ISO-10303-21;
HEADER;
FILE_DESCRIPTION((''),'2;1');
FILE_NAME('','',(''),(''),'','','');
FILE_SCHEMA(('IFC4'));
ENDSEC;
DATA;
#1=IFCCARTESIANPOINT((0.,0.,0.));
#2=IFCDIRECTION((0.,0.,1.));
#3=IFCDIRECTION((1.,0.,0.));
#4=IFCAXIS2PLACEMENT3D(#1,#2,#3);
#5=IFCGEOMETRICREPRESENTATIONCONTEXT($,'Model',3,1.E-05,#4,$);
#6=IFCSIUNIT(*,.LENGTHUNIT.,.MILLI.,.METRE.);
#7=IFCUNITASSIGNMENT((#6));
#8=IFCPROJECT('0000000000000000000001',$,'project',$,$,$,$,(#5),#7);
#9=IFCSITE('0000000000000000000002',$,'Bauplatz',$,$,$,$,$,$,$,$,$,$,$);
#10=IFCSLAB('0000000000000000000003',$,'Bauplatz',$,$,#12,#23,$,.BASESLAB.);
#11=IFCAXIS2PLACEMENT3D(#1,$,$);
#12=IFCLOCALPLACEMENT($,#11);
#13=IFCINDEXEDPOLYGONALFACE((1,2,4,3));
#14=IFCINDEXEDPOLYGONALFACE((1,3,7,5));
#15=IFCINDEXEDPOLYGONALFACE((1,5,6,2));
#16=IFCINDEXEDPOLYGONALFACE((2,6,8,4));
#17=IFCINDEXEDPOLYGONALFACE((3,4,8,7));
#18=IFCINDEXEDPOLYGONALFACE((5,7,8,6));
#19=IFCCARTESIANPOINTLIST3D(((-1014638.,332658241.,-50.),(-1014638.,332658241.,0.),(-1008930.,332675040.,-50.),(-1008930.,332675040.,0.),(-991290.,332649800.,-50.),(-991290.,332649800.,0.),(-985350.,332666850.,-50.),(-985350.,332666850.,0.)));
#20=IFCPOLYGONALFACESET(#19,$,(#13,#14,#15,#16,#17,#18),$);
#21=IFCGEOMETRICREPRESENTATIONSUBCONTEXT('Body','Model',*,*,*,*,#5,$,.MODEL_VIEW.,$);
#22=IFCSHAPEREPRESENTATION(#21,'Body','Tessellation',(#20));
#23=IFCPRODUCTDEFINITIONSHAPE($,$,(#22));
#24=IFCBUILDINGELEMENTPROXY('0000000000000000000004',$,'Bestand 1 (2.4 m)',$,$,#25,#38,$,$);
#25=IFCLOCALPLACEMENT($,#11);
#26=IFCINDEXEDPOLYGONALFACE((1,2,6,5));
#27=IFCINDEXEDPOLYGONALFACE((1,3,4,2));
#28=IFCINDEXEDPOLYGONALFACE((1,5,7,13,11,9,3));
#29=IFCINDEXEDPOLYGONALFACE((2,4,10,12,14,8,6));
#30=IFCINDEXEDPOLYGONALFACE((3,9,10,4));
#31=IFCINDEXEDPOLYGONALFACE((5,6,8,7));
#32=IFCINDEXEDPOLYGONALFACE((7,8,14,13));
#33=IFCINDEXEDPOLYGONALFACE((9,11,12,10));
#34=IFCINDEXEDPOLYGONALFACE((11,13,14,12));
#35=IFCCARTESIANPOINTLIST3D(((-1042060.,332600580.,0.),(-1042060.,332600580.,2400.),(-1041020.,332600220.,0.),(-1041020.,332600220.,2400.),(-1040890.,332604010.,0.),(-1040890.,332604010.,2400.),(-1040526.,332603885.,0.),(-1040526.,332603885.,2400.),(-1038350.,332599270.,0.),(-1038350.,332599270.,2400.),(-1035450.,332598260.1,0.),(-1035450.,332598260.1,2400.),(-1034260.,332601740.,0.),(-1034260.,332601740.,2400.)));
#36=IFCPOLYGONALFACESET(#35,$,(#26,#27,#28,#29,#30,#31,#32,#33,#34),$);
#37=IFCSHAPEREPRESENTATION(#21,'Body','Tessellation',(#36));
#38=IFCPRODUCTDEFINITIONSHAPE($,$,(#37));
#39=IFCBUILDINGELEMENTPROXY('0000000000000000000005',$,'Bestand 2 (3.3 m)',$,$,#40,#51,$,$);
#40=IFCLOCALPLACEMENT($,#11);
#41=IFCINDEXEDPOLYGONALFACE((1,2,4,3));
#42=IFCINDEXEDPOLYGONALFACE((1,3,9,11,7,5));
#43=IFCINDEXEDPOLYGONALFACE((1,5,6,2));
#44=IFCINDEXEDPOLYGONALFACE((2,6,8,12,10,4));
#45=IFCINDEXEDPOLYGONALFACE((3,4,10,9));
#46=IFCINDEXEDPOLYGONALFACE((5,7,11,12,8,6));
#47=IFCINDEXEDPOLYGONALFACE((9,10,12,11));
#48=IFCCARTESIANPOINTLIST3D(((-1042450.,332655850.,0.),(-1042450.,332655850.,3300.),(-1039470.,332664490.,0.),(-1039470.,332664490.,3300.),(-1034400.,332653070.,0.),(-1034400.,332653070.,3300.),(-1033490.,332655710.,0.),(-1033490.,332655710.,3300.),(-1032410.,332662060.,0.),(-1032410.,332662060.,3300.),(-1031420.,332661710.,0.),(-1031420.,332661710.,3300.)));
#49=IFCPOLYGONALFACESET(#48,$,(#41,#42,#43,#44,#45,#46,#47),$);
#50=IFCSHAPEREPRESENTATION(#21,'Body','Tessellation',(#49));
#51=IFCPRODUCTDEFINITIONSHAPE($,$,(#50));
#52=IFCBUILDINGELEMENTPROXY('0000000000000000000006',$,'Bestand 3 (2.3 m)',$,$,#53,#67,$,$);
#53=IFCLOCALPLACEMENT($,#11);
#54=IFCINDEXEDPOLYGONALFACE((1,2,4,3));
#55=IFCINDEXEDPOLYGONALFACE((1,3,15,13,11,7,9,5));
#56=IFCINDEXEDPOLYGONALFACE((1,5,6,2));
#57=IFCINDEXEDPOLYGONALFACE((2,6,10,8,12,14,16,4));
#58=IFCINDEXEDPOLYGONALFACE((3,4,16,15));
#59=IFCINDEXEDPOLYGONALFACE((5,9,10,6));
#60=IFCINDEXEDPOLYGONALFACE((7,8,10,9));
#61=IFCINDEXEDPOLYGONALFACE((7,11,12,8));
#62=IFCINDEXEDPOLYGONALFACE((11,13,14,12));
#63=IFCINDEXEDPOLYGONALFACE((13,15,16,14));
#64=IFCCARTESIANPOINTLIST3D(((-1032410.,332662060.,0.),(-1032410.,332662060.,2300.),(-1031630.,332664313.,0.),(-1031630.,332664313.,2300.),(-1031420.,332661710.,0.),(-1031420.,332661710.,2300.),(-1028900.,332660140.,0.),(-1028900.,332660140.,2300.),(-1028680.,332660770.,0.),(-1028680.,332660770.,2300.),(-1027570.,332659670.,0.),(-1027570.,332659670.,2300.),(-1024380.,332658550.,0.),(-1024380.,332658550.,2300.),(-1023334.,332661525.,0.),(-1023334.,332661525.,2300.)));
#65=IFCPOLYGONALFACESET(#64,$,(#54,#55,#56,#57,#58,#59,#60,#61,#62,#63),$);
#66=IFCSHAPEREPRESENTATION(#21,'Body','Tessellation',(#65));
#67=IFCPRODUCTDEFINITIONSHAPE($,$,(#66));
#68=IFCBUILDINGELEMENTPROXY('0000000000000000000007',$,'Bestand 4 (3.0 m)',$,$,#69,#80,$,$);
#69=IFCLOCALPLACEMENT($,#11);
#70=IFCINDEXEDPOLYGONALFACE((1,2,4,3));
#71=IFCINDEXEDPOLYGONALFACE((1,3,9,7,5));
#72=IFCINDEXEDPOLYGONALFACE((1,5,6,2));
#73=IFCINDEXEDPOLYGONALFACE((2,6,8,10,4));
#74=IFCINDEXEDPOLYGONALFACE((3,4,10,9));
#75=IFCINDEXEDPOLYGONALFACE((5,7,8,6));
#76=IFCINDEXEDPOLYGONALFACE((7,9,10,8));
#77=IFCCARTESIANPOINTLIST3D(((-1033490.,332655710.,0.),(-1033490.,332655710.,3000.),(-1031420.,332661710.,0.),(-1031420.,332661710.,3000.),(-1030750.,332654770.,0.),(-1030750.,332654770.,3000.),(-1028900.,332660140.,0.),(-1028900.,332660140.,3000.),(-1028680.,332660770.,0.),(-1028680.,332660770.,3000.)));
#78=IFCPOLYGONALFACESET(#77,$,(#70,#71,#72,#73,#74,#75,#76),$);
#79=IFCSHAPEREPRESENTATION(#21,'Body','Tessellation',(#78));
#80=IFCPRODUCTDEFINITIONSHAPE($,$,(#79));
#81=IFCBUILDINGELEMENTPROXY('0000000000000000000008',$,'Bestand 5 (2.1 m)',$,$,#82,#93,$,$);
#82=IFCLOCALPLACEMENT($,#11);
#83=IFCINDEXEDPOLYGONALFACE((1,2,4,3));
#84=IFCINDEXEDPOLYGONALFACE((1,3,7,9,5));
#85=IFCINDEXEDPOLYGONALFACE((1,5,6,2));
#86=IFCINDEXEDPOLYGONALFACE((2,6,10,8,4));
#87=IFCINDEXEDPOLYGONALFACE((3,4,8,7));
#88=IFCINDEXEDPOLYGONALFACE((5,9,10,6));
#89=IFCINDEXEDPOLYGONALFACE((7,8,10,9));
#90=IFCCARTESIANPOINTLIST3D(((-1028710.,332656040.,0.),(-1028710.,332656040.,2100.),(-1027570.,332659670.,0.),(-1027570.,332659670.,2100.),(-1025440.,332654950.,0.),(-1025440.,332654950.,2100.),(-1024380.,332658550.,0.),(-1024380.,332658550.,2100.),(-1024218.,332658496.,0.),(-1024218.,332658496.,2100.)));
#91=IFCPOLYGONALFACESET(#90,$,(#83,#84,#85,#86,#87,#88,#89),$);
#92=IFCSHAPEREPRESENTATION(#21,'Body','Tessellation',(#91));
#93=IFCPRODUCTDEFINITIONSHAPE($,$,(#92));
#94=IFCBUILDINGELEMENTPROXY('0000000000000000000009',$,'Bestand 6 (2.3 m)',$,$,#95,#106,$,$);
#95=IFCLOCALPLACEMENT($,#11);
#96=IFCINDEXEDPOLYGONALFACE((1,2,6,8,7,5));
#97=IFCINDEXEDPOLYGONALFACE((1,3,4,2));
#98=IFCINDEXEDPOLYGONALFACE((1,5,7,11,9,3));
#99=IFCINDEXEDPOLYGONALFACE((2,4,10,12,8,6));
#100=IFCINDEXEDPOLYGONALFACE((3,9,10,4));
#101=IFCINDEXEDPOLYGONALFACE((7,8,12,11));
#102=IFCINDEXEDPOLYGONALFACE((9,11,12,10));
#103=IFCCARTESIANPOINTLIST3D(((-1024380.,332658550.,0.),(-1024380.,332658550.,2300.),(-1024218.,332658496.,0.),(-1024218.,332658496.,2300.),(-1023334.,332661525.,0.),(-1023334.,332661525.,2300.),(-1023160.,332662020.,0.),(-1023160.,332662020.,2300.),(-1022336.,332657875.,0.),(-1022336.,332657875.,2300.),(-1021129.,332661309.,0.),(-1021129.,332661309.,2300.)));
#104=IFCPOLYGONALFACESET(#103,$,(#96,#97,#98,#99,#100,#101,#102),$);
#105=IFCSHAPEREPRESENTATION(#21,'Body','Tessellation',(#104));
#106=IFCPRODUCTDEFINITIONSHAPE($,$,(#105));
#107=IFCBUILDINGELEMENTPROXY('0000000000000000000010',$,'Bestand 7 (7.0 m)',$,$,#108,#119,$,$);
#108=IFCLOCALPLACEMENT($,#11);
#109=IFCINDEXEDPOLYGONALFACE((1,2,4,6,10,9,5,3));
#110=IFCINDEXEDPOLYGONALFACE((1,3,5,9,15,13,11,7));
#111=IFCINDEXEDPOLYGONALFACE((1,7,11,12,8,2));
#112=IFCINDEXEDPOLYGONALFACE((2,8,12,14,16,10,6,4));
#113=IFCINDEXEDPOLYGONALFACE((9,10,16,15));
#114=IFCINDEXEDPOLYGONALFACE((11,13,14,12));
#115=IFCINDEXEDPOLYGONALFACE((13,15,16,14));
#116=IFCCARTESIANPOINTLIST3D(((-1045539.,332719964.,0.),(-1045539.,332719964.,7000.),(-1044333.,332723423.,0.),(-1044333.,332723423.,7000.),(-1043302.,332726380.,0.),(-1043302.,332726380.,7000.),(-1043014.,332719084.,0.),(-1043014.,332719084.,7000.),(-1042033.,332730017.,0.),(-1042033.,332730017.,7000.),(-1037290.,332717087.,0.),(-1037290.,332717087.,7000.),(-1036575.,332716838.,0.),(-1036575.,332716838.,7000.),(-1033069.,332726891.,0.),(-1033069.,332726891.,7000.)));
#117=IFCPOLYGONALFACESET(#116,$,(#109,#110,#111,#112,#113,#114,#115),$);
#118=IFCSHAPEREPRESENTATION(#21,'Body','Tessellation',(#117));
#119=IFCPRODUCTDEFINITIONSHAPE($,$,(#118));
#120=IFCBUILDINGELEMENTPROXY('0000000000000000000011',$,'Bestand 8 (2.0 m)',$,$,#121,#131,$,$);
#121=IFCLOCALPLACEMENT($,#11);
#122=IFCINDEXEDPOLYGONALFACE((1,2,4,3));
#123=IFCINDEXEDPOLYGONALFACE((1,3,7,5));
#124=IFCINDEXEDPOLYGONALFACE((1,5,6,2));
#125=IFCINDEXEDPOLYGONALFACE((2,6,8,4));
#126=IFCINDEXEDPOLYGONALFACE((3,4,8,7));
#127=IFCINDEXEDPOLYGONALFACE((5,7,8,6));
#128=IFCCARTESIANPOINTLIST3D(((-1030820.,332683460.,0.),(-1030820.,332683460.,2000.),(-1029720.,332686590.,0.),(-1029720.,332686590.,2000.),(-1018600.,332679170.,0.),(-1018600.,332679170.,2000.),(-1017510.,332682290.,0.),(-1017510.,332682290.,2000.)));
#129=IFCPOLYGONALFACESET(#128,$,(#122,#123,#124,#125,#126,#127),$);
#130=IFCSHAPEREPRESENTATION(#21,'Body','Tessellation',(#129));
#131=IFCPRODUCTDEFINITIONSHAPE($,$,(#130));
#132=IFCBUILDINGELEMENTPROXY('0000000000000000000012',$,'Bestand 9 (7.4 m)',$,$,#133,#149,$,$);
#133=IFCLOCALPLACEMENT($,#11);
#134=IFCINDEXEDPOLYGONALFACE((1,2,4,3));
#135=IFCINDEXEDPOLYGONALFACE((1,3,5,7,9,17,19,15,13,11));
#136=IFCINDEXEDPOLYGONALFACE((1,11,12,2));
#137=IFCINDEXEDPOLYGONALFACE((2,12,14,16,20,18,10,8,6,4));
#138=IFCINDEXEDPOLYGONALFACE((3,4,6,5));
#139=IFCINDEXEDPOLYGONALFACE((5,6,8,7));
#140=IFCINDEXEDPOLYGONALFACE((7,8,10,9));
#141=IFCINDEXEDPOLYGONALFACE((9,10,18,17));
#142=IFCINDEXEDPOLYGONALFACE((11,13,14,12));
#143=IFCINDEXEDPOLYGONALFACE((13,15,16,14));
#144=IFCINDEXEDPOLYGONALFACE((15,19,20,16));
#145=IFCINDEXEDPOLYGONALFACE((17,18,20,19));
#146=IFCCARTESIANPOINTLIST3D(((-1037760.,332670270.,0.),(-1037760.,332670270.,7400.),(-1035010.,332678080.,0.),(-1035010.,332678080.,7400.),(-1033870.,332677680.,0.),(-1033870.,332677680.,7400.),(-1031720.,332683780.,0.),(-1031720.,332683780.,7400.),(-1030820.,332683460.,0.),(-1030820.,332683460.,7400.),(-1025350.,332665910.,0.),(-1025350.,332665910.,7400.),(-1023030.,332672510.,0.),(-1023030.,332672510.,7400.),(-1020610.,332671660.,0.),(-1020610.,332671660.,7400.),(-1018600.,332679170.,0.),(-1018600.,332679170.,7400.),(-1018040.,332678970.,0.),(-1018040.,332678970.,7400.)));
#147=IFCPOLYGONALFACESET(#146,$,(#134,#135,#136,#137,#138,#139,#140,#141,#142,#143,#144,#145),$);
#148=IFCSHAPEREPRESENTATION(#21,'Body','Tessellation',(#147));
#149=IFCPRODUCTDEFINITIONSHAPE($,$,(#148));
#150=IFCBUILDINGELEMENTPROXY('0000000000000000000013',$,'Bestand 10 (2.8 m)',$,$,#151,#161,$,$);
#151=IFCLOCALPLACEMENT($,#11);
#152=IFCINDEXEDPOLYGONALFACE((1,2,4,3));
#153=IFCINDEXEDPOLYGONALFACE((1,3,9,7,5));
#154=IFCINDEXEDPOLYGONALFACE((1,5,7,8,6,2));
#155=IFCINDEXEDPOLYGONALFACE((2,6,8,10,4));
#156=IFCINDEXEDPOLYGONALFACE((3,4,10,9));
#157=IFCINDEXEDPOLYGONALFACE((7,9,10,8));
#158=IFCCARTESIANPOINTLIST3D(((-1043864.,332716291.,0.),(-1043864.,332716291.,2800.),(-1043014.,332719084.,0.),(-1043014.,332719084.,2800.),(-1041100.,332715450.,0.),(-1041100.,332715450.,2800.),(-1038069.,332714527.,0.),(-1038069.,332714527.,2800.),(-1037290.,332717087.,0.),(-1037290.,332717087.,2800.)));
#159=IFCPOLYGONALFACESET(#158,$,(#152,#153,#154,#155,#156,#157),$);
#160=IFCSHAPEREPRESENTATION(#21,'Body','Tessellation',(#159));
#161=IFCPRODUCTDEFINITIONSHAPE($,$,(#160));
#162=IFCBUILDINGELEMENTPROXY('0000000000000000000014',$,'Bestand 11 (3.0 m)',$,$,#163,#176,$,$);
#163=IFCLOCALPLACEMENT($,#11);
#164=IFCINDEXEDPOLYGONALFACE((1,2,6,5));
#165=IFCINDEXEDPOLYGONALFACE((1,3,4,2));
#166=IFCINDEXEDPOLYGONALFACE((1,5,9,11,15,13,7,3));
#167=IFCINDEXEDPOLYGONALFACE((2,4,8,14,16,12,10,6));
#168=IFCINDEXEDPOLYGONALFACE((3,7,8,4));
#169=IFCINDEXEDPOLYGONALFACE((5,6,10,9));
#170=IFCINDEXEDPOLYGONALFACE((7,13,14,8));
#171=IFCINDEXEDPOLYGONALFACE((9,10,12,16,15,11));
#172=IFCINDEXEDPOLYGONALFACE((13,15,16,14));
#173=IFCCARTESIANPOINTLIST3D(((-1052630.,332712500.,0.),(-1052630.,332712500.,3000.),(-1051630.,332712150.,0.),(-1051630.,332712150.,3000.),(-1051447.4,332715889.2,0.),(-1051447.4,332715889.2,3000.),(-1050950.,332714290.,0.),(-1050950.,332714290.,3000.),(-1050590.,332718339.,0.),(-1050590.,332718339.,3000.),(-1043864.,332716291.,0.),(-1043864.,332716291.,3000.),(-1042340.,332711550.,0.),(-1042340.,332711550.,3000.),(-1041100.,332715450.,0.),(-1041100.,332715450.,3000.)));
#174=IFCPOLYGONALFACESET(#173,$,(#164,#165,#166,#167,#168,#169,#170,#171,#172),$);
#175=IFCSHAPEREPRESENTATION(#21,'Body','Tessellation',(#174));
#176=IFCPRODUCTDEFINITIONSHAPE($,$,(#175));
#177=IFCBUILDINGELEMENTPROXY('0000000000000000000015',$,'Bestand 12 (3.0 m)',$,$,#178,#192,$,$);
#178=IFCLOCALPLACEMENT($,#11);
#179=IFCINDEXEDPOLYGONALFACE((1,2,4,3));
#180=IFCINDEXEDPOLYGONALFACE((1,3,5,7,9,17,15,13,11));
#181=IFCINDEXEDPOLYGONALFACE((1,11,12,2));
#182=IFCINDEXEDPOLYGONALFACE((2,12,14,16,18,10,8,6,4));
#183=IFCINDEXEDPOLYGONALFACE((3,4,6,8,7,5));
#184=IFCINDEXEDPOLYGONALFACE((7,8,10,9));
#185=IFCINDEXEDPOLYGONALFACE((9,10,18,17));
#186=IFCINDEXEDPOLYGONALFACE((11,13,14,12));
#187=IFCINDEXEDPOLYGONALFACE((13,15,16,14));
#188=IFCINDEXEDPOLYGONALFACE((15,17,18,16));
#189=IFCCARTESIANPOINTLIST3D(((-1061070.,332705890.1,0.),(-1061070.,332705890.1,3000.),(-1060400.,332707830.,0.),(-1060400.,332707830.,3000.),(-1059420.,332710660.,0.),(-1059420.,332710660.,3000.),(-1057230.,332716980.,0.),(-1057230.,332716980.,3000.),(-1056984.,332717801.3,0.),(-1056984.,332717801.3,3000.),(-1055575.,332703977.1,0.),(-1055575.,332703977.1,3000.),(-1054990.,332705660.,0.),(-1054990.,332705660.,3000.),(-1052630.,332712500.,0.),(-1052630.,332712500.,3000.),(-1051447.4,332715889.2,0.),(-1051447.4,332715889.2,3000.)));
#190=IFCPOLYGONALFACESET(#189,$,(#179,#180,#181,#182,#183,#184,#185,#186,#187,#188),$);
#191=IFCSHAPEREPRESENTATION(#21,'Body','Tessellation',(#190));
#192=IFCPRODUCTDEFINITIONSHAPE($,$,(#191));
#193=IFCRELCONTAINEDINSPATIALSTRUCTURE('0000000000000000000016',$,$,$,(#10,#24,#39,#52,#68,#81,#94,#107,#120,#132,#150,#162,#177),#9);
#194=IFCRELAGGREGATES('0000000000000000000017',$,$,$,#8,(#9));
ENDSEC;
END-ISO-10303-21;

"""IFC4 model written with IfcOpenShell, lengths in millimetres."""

from ifc_helpers import new_model, si_unit, frame, origin_with_axes, place, context, subcontext, project, spatial, indexed_curve, outline, extrude, element, save


model = new_model("IFC4")

# Units and contexts
model_context = context("Model", 3, precision=1e-05, world=origin_with_axes())
body_context = subcontext(model_context, "Body", "Model", "MODEL_VIEW")
ifc_project = project(units=[si_unit("LENGTHUNIT", "METRE", prefix="MILLI")], contexts=[model_context])

# Site
site = spatial("IfcSite", under=ifc_project, Name="Bauplatz")

# Slab
slab_placement = place(None, frame((0.0, 0.0, -50.0), z_axis=(0.0, 0.0, 1.0), x_axis=(1.0, 0.0, 0.0)))
element("IfcSlab", 1, at=slab_placement, inside=site, Name="Bauplatz", PredefinedType="BASESLAB", context=body_context, shape_type="SweptSolid", body=[
    extrude(outline(indexed_curve([(-991290.0, 332649800.0), (-985350.0, 332666850.0), (-1008930.0, 332675040.0), (-1014638.0, 332658241.0)])), None, (0.0, 0.0, 1.0), 50.0),
])

# Building element proxies
proxy_1_placement = place(None, origin_with_axes())
element("IfcBuildingElementProxy", 2, at=proxy_1_placement, inside=site, Name="Bestand 1 (2.4 m)", context=body_context, shape_type="SweptSolid", body=[
    extrude(outline(indexed_curve([(-1040526.0, 332603885.0), (-1040890.0, 332604010.0), (-1042060.0, 332600580.0), (-1041020.0, 332600220.0), (-1038350.0, 332599270.0), (-1035450.0, 332598260.1), (-1034260.0, 332601740.0)])), None, (0.0, 0.0, 1.0), 2400.0),
])
proxy_2_placement = place(None, origin_with_axes())
element("IfcBuildingElementProxy", 3, at=proxy_2_placement, inside=site, Name="Bestand 2 (3.3 m)", context=body_context, shape_type="SweptSolid", body=[
    extrude(outline(indexed_curve([(-1032410.0, 332662060.0), (-1039470.0, 332664490.0), (-1042450.0, 332655850.0), (-1034400.0, 332653070.0), (-1033490.0, 332655710.0), (-1031420.0, 332661710.0)])), None, (0.0, 0.0, 1.0), 3300.0),
])
proxy_3_placement = place(None, origin_with_axes())
element("IfcBuildingElementProxy", 4, at=proxy_3_placement, inside=site, Name="Bestand 3 (2.3 m)", context=body_context, shape_type="SweptSolid", body=[
    extrude(outline(indexed_curve([(-1023334.0, 332661525.0), (-1031630.0, 332664313.0), (-1032410.0, 332662060.0), (-1031420.0, 332661710.0), (-1028680.0, 332660770.0), (-1028900.0, 332660140.0), (-1027570.0, 332659670.0), (-1024380.0, 332658550.0)])), None, (0.0, 0.0, 1.0), 2300.0),
])
proxy_4_placement = place(None, origin_with_axes())
element("IfcBuildingElementProxy", 5, at=proxy_4_placement, inside=site, Name="Bestand 4 (3.0 m)", context=body_context, shape_type="SweptSolid", body=[
    extrude(outline(indexed_curve([(-1028680.0, 332660770.0), (-1031420.0, 332661710.0), (-1033490.0, 332655710.0), (-1030750.0, 332654770.0), (-1028900.0, 332660140.0)])), None, (0.0, 0.0, 1.0), 3000.0),
])
proxy_5_placement = place(None, origin_with_axes())
element("IfcBuildingElementProxy", 6, at=proxy_5_placement, inside=site, Name="Bestand 5 (2.1 m)", context=body_context, shape_type="SweptSolid", body=[
    extrude(outline(indexed_curve([(-1024380.0, 332658550.0), (-1027570.0, 332659670.0), (-1028710.0, 332656040.0), (-1025440.0, 332654950.0), (-1024218.0, 332658496.0)])), None, (0.0, 0.0, 1.0), 2100.0),
])
proxy_6_placement = place(None, origin_with_axes())
element("IfcBuildingElementProxy", 7, at=proxy_6_placement, inside=site, Name="Bestand 6 (2.3 m)", context=body_context, shape_type="SweptSolid", body=[
    extrude(outline(indexed_curve([(-1021129.0, 332661309.0), (-1023160.0, 332662020.0), (-1023334.0, 332661525.0), (-1024380.0, 332658550.0), (-1024218.0, 332658496.0), (-1022336.0, 332657875.0)])), None, (0.0, 0.0, 1.0), 2300.0),
])
proxy_7_placement = place(None, origin_with_axes())
element("IfcBuildingElementProxy", 8, at=proxy_7_placement, inside=site, Name="Bestand 7 (7.0 m)", context=body_context, shape_type="SweptSolid", body=[
    extrude(outline(indexed_curve([(-1033069.0, 332726891.0), (-1042033.0, 332730017.0), (-1043302.0, 332726380.0), (-1044333.0, 332723423.0), (-1045539.0, 332719964.0), (-1043014.0, 332719084.0), (-1037290.0, 332717087.0), (-1036575.0, 332716838.0)])), None, (0.0, 0.0, 1.0), 7000.0),
])
proxy_8_placement = place(None, origin_with_axes())
element("IfcBuildingElementProxy", 9, at=proxy_8_placement, inside=site, Name="Bestand 8 (2.0 m)", context=body_context, shape_type="SweptSolid", body=[
    extrude(outline(indexed_curve([(-1017510.0, 332682290.0), (-1029720.0, 332686590.0), (-1030820.0, 332683460.0), (-1018600.0, 332679170.0)])), None, (0.0, 0.0, 1.0), 2000.0),
])
proxy_9_placement = place(None, origin_with_axes())
element("IfcBuildingElementProxy", 10, at=proxy_9_placement, inside=site, Name="Bestand 9 (7.4 m)", context=body_context, shape_type="SweptSolid", body=[
    extrude(outline(indexed_curve([(-1030820.0, 332683460.0), (-1031720.0, 332683780.0), (-1033870.0, 332677680.0), (-1035010.0, 332678080.0), (-1037760.0, 332670270.0), (-1025350.0, 332665910.0), (-1023030.0, 332672510.0), (-1020610.0, 332671660.0), (-1018040.0, 332678970.0), (-1018600.0, 332679170.0)])), None, (0.0, 0.0, 1.0), 7400.0),
])
proxy_10_placement = place(None, origin_with_axes())
element("IfcBuildingElementProxy", 11, at=proxy_10_placement, inside=site, Name="Bestand 10 (2.8 m)", context=body_context, shape_type="SweptSolid", body=[
    extrude(outline(indexed_curve([(-1037290.0, 332717087.0), (-1043014.0, 332719084.0), (-1043864.0, 332716291.0), (-1041100.0, 332715450.0), (-1038069.0, 332714527.0)])), None, (0.0, 0.0, 1.0), 2800.0),
])
proxy_11_placement = place(None, origin_with_axes())
element("IfcBuildingElementProxy", 12, at=proxy_11_placement, inside=site, Name="Bestand 11 (3.0 m)", context=body_context, shape_type="SweptSolid", body=[
    extrude(outline(indexed_curve([(-1043864.0, 332716291.0), (-1050590.0, 332718339.0), (-1051447.4, 332715889.2), (-1052630.0, 332712500.0), (-1051630.0, 332712150.0), (-1050950.0, 332714290.0), (-1042340.0, 332711550.0), (-1041100.0, 332715450.0)])), None, (0.0, 0.0, 1.0), 3000.0),
])
proxy_12_placement = place(None, origin_with_axes())
element("IfcBuildingElementProxy", 13, at=proxy_12_placement, inside=site, Name="Bestand 12 (3.0 m)", context=body_context, shape_type="SweptSolid", body=[
    extrude(outline(indexed_curve([(-1051447.4, 332715889.2), (-1056984.0, 332717801.3), (-1057230.0, 332716980.0), (-1059420.0, 332710660.0), (-1060400.0, 332707830.0), (-1061070.0, 332705890.1), (-1055575.0, 332703977.1), (-1054990.0, 332705660.0), (-1052630.0, 332712500.0)])), None, (0.0, 0.0, 1.0), 3000.0),
])

save(model, "model.ifc")
